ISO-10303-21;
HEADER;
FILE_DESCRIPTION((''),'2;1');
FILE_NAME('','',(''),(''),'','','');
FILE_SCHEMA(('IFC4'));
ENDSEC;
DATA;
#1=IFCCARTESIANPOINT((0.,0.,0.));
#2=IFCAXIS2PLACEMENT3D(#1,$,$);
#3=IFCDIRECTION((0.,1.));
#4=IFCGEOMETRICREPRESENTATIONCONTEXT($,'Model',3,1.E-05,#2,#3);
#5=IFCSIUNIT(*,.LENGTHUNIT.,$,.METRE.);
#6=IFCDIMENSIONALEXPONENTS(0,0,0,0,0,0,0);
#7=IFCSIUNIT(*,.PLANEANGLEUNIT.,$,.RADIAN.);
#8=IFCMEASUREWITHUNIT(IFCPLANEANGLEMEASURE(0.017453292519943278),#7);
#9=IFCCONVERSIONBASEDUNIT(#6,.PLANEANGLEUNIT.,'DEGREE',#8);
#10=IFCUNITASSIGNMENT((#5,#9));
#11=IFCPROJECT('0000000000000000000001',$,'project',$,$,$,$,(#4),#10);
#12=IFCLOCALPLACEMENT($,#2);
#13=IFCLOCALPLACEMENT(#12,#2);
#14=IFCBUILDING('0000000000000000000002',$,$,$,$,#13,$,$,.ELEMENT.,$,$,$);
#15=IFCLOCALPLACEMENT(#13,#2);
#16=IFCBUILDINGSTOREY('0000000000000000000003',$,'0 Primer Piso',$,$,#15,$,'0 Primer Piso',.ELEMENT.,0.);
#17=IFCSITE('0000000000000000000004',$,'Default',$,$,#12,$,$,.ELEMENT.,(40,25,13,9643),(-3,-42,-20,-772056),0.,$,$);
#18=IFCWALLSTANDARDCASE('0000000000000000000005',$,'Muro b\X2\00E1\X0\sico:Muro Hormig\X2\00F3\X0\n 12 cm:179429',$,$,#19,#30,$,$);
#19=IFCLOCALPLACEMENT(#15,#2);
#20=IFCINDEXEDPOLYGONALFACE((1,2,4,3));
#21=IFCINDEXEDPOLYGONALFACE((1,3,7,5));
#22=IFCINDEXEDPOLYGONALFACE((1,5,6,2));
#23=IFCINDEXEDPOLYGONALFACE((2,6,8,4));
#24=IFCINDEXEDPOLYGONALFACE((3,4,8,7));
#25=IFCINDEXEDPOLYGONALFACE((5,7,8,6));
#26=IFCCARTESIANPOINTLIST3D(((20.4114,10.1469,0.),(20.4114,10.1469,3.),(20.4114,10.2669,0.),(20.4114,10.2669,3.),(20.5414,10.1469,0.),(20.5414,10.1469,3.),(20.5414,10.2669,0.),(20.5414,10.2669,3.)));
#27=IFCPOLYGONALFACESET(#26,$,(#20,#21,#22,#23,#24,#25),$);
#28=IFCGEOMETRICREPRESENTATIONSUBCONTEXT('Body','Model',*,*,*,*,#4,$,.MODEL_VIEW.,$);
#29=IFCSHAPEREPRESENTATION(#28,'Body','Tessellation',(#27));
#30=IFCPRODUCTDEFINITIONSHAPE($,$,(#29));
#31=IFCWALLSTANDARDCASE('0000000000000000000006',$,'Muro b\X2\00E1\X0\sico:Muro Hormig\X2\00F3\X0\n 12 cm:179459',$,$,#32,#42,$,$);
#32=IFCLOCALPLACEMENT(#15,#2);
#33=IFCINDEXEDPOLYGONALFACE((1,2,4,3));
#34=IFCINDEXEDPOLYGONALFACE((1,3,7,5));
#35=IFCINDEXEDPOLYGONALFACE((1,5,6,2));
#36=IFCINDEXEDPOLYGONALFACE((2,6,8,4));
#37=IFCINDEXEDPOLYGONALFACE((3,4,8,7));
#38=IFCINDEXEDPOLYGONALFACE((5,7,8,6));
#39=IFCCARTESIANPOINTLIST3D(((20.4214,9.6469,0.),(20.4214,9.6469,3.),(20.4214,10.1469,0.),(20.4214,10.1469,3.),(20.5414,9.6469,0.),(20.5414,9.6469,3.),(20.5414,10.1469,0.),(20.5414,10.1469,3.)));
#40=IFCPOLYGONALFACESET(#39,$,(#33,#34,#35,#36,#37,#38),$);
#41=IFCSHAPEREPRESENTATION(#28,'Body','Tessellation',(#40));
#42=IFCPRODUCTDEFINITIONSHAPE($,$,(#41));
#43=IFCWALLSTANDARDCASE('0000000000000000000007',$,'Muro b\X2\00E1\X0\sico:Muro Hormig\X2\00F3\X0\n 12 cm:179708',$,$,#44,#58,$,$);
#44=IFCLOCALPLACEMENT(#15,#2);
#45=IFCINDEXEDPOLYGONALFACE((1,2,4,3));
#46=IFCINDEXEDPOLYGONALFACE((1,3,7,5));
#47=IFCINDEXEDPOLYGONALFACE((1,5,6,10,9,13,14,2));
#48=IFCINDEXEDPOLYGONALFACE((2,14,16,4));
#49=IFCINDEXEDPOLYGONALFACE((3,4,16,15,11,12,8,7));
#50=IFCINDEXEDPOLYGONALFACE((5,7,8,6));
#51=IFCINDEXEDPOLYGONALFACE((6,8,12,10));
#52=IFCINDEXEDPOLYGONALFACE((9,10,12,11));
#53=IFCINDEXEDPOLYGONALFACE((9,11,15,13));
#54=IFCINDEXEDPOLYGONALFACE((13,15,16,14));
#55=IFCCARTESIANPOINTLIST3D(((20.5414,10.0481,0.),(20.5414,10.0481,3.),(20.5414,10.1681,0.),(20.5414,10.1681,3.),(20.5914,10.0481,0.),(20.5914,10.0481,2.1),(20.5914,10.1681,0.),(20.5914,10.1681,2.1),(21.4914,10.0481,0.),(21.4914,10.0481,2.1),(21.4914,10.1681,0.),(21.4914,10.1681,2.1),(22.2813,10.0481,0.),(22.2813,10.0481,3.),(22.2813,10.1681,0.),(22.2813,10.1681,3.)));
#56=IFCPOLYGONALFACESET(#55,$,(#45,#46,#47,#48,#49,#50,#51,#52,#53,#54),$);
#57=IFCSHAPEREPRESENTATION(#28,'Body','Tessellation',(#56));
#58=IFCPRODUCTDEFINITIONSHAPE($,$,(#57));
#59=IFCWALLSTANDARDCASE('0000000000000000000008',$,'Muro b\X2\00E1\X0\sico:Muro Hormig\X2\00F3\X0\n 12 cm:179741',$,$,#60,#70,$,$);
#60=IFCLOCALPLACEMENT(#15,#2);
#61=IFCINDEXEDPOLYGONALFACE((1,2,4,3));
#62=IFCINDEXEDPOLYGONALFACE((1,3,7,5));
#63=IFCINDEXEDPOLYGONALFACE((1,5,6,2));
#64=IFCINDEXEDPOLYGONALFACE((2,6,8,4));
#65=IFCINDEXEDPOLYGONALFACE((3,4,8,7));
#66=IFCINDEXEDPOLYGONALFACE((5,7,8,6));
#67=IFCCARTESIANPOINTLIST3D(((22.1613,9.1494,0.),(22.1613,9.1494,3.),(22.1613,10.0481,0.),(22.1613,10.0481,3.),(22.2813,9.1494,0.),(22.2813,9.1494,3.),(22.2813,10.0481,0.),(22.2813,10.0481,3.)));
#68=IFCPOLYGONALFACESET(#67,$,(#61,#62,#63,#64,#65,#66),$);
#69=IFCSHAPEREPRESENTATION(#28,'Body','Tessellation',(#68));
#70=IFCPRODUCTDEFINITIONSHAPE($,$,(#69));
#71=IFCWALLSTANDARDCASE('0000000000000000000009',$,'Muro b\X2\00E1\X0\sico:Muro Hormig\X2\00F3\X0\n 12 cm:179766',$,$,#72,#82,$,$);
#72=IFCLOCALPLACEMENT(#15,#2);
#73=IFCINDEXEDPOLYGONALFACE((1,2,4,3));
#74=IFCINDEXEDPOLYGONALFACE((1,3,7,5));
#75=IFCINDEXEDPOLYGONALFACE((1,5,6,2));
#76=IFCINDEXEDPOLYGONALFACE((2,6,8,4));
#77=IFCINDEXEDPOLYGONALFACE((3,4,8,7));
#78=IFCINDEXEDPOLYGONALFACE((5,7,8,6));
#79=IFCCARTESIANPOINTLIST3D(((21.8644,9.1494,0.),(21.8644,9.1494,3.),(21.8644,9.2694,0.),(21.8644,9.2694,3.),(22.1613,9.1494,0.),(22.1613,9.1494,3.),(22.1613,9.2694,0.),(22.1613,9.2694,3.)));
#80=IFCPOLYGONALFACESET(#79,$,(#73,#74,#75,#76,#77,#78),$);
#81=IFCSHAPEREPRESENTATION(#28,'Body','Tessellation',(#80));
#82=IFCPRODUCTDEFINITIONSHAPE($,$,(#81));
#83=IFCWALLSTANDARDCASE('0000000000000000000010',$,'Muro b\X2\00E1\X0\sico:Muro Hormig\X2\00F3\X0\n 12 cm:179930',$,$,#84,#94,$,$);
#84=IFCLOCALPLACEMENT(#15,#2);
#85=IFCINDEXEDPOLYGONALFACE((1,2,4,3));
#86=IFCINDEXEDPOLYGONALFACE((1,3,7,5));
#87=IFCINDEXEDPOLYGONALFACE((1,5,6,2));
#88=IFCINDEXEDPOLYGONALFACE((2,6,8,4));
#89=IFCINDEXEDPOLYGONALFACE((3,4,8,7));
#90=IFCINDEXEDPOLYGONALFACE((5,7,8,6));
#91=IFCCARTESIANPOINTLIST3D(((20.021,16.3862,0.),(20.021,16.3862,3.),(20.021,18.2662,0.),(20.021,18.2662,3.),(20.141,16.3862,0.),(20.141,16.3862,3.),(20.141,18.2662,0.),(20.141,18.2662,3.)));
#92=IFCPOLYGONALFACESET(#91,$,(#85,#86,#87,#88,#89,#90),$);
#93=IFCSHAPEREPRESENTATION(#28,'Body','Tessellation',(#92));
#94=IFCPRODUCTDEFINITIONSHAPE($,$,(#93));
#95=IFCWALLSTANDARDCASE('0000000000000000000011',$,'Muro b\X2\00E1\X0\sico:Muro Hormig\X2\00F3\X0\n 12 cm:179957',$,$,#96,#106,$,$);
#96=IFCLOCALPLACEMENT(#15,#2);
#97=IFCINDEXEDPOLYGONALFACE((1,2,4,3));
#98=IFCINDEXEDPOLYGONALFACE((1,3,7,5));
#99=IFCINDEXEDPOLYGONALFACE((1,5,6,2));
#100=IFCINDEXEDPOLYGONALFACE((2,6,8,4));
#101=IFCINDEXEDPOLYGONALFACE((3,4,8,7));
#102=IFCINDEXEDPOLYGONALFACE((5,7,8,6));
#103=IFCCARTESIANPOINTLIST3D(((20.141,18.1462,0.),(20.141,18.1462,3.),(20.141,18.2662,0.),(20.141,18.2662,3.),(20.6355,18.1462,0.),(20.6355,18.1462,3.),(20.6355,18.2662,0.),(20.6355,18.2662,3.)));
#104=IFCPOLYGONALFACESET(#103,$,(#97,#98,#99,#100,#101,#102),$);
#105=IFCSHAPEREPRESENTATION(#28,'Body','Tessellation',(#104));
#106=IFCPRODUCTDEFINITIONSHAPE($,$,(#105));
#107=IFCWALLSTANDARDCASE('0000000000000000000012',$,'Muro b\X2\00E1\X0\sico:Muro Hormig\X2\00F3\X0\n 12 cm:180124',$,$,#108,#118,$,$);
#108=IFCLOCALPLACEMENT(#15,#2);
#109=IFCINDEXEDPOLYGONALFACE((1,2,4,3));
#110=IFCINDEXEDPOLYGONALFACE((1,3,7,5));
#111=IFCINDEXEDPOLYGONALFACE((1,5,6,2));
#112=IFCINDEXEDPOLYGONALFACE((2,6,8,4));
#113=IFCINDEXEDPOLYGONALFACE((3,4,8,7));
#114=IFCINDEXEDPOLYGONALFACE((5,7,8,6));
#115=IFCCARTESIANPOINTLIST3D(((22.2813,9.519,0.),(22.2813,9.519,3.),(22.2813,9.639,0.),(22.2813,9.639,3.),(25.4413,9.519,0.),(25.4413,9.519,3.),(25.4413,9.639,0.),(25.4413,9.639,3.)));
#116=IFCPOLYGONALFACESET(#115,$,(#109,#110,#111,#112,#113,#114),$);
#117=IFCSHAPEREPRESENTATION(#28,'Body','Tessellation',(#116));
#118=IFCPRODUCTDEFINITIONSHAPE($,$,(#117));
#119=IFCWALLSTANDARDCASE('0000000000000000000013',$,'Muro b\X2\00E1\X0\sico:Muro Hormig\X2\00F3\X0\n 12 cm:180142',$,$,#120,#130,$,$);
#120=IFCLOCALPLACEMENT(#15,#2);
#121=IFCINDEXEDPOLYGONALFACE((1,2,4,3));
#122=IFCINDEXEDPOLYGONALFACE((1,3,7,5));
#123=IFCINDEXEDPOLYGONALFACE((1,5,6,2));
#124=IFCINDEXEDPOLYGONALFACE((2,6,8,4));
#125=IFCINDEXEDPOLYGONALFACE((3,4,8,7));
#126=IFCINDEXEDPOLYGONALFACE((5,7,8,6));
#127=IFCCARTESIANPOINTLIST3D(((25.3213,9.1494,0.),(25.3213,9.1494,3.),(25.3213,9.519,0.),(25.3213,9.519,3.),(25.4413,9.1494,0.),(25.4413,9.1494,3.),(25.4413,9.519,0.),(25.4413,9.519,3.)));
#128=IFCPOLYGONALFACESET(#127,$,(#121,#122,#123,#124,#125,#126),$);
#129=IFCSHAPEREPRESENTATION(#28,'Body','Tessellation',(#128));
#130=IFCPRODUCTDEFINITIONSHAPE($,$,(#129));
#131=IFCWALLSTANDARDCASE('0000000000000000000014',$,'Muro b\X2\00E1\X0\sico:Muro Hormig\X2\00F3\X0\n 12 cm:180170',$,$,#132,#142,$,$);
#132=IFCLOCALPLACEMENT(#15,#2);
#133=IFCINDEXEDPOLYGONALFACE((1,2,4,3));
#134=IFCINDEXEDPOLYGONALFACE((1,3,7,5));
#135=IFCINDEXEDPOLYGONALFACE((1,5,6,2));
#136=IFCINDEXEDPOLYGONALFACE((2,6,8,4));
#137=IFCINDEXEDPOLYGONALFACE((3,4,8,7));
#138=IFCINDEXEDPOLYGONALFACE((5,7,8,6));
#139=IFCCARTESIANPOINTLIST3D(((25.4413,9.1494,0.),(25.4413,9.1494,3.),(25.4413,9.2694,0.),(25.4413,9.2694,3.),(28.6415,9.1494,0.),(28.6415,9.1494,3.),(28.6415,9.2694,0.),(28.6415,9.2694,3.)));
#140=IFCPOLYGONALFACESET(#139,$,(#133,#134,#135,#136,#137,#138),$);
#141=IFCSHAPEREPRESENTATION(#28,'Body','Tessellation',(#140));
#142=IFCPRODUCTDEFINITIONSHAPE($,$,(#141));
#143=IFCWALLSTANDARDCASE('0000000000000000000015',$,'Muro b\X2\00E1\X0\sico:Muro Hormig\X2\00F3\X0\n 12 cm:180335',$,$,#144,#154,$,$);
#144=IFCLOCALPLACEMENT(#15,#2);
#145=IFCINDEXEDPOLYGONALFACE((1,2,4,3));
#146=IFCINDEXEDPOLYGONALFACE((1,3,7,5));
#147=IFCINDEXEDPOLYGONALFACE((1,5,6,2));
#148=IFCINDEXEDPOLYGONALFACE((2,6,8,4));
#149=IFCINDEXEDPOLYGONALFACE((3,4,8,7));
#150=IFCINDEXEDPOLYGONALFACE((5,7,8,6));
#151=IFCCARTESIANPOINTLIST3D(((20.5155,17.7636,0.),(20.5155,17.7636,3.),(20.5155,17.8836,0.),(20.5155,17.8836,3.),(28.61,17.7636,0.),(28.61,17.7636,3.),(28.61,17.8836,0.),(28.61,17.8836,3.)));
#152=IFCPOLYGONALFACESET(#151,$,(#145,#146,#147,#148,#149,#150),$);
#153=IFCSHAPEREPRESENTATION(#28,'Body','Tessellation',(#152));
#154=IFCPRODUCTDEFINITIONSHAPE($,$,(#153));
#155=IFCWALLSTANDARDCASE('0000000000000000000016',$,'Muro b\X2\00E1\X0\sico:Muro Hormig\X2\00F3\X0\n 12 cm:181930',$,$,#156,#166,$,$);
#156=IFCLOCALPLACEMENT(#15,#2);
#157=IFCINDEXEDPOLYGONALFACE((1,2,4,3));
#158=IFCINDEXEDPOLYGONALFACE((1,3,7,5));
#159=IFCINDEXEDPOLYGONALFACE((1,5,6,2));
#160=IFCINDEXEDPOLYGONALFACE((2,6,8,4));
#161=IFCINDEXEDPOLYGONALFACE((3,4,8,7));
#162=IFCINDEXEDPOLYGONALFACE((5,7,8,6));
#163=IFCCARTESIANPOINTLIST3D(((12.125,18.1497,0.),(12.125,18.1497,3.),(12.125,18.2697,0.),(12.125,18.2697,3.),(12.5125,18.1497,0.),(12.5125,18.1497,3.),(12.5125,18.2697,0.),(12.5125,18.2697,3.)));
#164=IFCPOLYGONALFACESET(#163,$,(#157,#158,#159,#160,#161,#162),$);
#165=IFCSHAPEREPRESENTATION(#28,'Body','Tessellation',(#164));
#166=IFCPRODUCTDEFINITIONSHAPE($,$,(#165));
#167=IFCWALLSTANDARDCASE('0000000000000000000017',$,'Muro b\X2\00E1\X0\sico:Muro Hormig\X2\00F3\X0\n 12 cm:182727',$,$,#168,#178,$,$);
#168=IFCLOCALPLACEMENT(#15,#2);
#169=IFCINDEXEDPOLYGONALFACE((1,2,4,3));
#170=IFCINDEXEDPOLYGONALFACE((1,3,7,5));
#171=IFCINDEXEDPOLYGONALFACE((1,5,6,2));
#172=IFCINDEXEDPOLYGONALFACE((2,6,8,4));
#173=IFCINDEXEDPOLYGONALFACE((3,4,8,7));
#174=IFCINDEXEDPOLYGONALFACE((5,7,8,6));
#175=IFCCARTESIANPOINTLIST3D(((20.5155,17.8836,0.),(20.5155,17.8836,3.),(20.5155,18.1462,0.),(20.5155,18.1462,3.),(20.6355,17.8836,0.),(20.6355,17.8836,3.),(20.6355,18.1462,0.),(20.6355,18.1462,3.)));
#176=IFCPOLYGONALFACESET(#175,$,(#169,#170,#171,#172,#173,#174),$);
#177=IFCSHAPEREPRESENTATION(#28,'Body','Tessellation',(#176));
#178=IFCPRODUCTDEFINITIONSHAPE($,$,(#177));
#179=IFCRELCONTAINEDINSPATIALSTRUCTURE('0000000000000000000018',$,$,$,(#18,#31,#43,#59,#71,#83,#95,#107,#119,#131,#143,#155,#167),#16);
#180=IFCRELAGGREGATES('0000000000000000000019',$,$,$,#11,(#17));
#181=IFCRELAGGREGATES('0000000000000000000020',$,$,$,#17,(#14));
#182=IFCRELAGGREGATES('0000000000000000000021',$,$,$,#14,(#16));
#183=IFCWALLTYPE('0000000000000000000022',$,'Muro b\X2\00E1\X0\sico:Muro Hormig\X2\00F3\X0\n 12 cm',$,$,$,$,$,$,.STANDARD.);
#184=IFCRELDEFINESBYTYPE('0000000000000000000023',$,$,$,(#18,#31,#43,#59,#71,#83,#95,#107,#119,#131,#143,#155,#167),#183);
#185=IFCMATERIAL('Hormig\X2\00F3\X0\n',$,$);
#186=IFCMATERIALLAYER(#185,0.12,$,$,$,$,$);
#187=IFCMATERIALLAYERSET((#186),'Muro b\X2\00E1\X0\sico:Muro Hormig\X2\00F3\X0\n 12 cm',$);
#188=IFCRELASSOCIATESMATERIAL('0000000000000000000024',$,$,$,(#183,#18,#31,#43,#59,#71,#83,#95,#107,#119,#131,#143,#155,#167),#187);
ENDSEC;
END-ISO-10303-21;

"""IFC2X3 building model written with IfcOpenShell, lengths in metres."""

from ifc_helpers import new_model, entity, si_unit, converted_unit, direction, frame, frame_2d, origin, place, context, subcontext, project, spatial, rectangle, extrude, material, layer, layer_set, layer_usage, type_object, element, save


model = new_model("IFC2X3")

# Units and contexts
model_context = context("Model", 3, precision=1e-05, world=origin(), true_north=direction((0.0, 1.0)))
body_context = subcontext(model_context, "Body", "Model", "MODEL_VIEW")
ifc_project = project(units=[si_unit("LENGTHUNIT", "METRE"), converted_unit("PLANEANGLEUNIT", "DEGREE", entity("IfcPlaneAngleMeasure", 0.017453292519943278), si_unit("PLANEANGLEUNIT", "RADIAN"), dimensions=[0, 0, 0, 0, 0, 0, 0])], contexts=[model_context])

# Site, building, storey
site_placement = place(None, origin())
site = spatial("IfcSite", under=ifc_project, at=site_placement, Name="Default", CompositionType="ELEMENT", RefLatitude=(40, 25, 13, 9643), RefLongitude=(-3, -42, -20, -772056), RefElevation=0.0)
building_placement = place(site_placement, origin())
building = spatial("IfcBuilding", under=site, at=building_placement, CompositionType="ELEMENT")
storey_placement = place(building_placement, origin())
storey = spatial("IfcBuildingStorey", under=building, at=storey_placement, Name="0 Primer Piso", LongName="0 Primer Piso", CompositionType="ELEMENT", Elevation=0.0)

# Walls
ifc_material = material(Name="Hormigón")
ifc_layer = layer(ifc_material, 0.12)
ifc_layer_set = layer_set([ifc_layer], Name="Muro básico:Muro Hormigón 12 cm")
wall_type = type_object("IfcWallType", Name="Muro básico:Muro Hormigón 12 cm", PredefinedType="STANDARD", material=ifc_layer_set)
ifc_layer_usage_1 = layer_usage(ifc_layer_set, "AXIS2", "NEGATIVE", 0.06)
wall_1_placement = place(storey_placement, frame((20.4114, 10.2069, 0.0)))
element("IfcWallStandardCase", 1, at=wall_1_placement, inside=storey, type_object=wall_type, material=ifc_layer_usage_1, Name="Muro básico:Muro Hormigón 12 cm:179429", context=body_context, shape_type="SweptSolid", body=[
    extrude(rectangle(XDim=0.13, YDim=0.12, at=frame_2d((0.065, 0.0), x_axis=(-1.0, 0.0))), origin(), (0.0, 0.0, 1.0), 3.0),
])
ifc_layer_usage_2 = layer_usage(ifc_layer_set, "AXIS2", "NEGATIVE", 0.06)
wall_2_placement = place(storey_placement, frame((20.4814, 10.1469, 0.0), z_axis=(0.0, 0.0, 1.0), x_axis=(0.0, -1.0, 0.0)))
element("IfcWallStandardCase", 2, at=wall_2_placement, inside=storey, type_object=wall_type, material=ifc_layer_usage_2, Name="Muro básico:Muro Hormigón 12 cm:179459", context=body_context, shape_type="SweptSolid", body=[
    extrude(rectangle(XDim=0.5, YDim=0.12, at=frame_2d((0.25, 0.0), x_axis=(-1.0, 0.0))), origin(), (0.0, 0.0, 1.0), 3.0),
])

# Wall, opening
ifc_layer_usage_3 = layer_usage(ifc_layer_set, "AXIS2", "NEGATIVE", 0.06)
wall_3_placement = place(storey_placement, frame((20.5414, 10.1081, 0.0)))
wall_3 = element("IfcWallStandardCase", 3, at=wall_3_placement, inside=storey, type_object=wall_type, material=ifc_layer_usage_3, Name="Muro básico:Muro Hormigón 12 cm:179708", context=body_context, shape_type="SweptSolid", body=[
    extrude(rectangle(XDim=1.7399, YDim=0.12, at=frame_2d((0.87, 0.0), x_axis=(1.0, 0.0))), origin(), (0.0, 0.0, 1.0), 3.0),
])
opening_placement = place(wall_3_placement, frame((0.95, 0.06, 0.0)))
element("IfcOpeningElement", 4, at=opening_placement, cuts=wall_3, ObjectType="Opening", context=body_context, shape_type="SweptSolid", body=[
    extrude(rectangle(XDim=2.1, YDim=0.9, at=frame_2d((1.05, 0.45), x_axis=(1.0, 0.0))), frame((0.0, 0.0, 0.0), z_axis=(0.0, -1.0, 0.0), x_axis=(0.0, 0.0, 1.0)), (0.0, 0.0, 1.0), 0.12),
])

# Walls
ifc_layer_usage_4 = layer_usage(ifc_layer_set, "AXIS2", "NEGATIVE", 0.06)
wall_4_placement = place(storey_placement, frame((22.2213, 10.0481, 0.0), z_axis=(0.0, 0.0, 1.0), x_axis=(0.0, -1.0, 0.0)))
element("IfcWallStandardCase", 5, at=wall_4_placement, inside=storey, type_object=wall_type, material=ifc_layer_usage_4, Name="Muro básico:Muro Hormigón 12 cm:179741", context=body_context, shape_type="SweptSolid", body=[
    extrude(rectangle(XDim=0.8988, YDim=0.12, at=frame_2d((0.4494, 0.0), x_axis=(-1.0, 0.0))), origin(), (0.0, 0.0, 1.0), 3.0),
])
ifc_layer_usage_5 = layer_usage(ifc_layer_set, "AXIS2", "NEGATIVE", 0.06)
wall_5_placement = place(storey_placement, frame((22.1613, 9.2094, 0.0), z_axis=(0.0, 0.0, 1.0), x_axis=(-1.0, 0.0, 0.0)))
element("IfcWallStandardCase", 6, at=wall_5_placement, inside=storey, type_object=wall_type, material=ifc_layer_usage_5, Name="Muro básico:Muro Hormigón 12 cm:179766", context=body_context, shape_type="SweptSolid", body=[
    extrude(rectangle(XDim=0.2969, YDim=0.12, at=frame_2d((0.1484, 0.0), x_axis=(-1.0, 0.0))), origin(), (0.0, 0.0, 1.0), 3.0),
])
ifc_layer_usage_6 = layer_usage(ifc_layer_set, "AXIS2", "NEGATIVE", 0.06)
wall_6_placement = place(storey_placement, frame((20.081, 16.3862, 0.0), z_axis=(0.0, 0.0, 1.0), x_axis=(0.0, 1.0, 0.0)))
element("IfcWallStandardCase", 7, at=wall_6_placement, inside=storey, type_object=wall_type, material=ifc_layer_usage_6, Name="Muro básico:Muro Hormigón 12 cm:179930", context=body_context, shape_type="SweptSolid", body=[
    extrude(rectangle(XDim=1.88, YDim=0.12, at=frame_2d((0.94, 0.0), x_axis=(-1.0, 0.0))), origin(), (0.0, 0.0, 1.0), 3.0),
])
ifc_layer_usage_7 = layer_usage(ifc_layer_set, "AXIS2", "NEGATIVE", 0.06)
wall_7_placement = place(storey_placement, frame((20.141, 18.2062, 0.0)))
element("IfcWallStandardCase", 8, at=wall_7_placement, inside=storey, type_object=wall_type, material=ifc_layer_usage_7, Name="Muro básico:Muro Hormigón 12 cm:179957", context=body_context, shape_type="SweptSolid", body=[
    extrude(rectangle(XDim=0.4945, YDim=0.12, at=frame_2d((0.2472, 0.0), x_axis=(-1.0, 0.0))), origin(), (0.0, 0.0, 1.0), 3.0),
])
ifc_layer_usage_8 = layer_usage(ifc_layer_set, "AXIS2", "NEGATIVE", 0.06)
wall_8_placement = place(storey_placement, frame((22.2813, 9.579, 0.0)))
element("IfcWallStandardCase", 9, at=wall_8_placement, inside=storey, type_object=wall_type, material=ifc_layer_usage_8, Name="Muro básico:Muro Hormigón 12 cm:180124", context=body_context, shape_type="SweptSolid", body=[
    extrude(rectangle(XDim=3.16, YDim=0.12, at=frame_2d((1.58, 0.0), x_axis=(-1.0, 0.0))), origin(), (0.0, 0.0, 1.0), 3.0),
])
ifc_layer_usage_9 = layer_usage(ifc_layer_set, "AXIS2", "NEGATIVE", 0.06)
wall_9_placement = place(storey_placement, frame((25.3813, 9.519, 0.0), z_axis=(0.0, 0.0, 1.0), x_axis=(0.0, -1.0, 0.0)))
element("IfcWallStandardCase", 10, at=wall_9_placement, inside=storey, type_object=wall_type, material=ifc_layer_usage_9, Name="Muro básico:Muro Hormigón 12 cm:180142", context=body_context, shape_type="SweptSolid", body=[
    extrude(rectangle(XDim=0.3696, YDim=0.12, at=frame_2d((0.1848, 0.0), x_axis=(-1.0, 0.0))), origin(), (0.0, 0.0, 1.0), 3.0),
])
ifc_layer_usage_10 = layer_usage(ifc_layer_set, "AXIS2", "NEGATIVE", 0.06)
wall_10_placement = place(storey_placement, frame((25.4413, 9.2094, 0.0)))
element("IfcWallStandardCase", 11, at=wall_10_placement, inside=storey, type_object=wall_type, material=ifc_layer_usage_10, Name="Muro básico:Muro Hormigón 12 cm:180170", context=body_context, shape_type="SweptSolid", body=[
    extrude(rectangle(XDim=3.2002, YDim=0.12, at=frame_2d((1.6001, 0.0), x_axis=(-1.0, 0.0))), origin(), (0.0, 0.0, 1.0), 3.0),
])
ifc_layer_usage_11 = layer_usage(ifc_layer_set, "AXIS2", "NEGATIVE", 0.06)
wall_11_placement = place(storey_placement, frame((20.5155, 17.8236, 0.0)))
element("IfcWallStandardCase", 12, at=wall_11_placement, inside=storey, type_object=wall_type, material=ifc_layer_usage_11, Name="Muro básico:Muro Hormigón 12 cm:180335", context=body_context, shape_type="SweptSolid", body=[
    extrude(rectangle(XDim=8.0945, YDim=0.12, at=frame_2d((4.0472, 0.0), x_axis=(-1.0, 0.0))), origin(), (0.0, 0.0, 1.0), 3.0),
])
ifc_layer_usage_12 = layer_usage(ifc_layer_set, "AXIS2", "NEGATIVE", 0.06)
wall_12_placement = place(storey_placement, frame((12.5125, 18.2097, 0.0), z_axis=(0.0, 0.0, 1.0), x_axis=(-1.0, 0.0, 0.0)))
element("IfcWallStandardCase", 13, at=wall_12_placement, inside=storey, type_object=wall_type, material=ifc_layer_usage_12, Name="Muro básico:Muro Hormigón 12 cm:181930", context=body_context, shape_type="SweptSolid", body=[
    extrude(rectangle(XDim=0.3875, YDim=0.12, at=frame_2d((0.1938, 0.0), x_axis=(-1.0, 0.0))), origin(), (0.0, 0.0, 1.0), 3.0),
])
ifc_layer_usage_13 = layer_usage(ifc_layer_set, "AXIS2", "NEGATIVE", 0.06)
wall_13_placement = place(storey_placement, frame((20.5755, 18.1462, 0.0), z_axis=(0.0, 0.0, 1.0), x_axis=(0.0, -1.0, 0.0)))
element("IfcWallStandardCase", 14, at=wall_13_placement, inside=storey, type_object=wall_type, material=ifc_layer_usage_13, Name="Muro básico:Muro Hormigón 12 cm:182727", context=body_context, shape_type="SweptSolid", body=[
    extrude(rectangle(XDim=0.2626, YDim=0.12, at=frame_2d((0.1313, 0.0), x_axis=(-1.0, 0.0))), origin(), (0.0, 0.0, 1.0), 3.0),
])

save(model, "model.ifc")
